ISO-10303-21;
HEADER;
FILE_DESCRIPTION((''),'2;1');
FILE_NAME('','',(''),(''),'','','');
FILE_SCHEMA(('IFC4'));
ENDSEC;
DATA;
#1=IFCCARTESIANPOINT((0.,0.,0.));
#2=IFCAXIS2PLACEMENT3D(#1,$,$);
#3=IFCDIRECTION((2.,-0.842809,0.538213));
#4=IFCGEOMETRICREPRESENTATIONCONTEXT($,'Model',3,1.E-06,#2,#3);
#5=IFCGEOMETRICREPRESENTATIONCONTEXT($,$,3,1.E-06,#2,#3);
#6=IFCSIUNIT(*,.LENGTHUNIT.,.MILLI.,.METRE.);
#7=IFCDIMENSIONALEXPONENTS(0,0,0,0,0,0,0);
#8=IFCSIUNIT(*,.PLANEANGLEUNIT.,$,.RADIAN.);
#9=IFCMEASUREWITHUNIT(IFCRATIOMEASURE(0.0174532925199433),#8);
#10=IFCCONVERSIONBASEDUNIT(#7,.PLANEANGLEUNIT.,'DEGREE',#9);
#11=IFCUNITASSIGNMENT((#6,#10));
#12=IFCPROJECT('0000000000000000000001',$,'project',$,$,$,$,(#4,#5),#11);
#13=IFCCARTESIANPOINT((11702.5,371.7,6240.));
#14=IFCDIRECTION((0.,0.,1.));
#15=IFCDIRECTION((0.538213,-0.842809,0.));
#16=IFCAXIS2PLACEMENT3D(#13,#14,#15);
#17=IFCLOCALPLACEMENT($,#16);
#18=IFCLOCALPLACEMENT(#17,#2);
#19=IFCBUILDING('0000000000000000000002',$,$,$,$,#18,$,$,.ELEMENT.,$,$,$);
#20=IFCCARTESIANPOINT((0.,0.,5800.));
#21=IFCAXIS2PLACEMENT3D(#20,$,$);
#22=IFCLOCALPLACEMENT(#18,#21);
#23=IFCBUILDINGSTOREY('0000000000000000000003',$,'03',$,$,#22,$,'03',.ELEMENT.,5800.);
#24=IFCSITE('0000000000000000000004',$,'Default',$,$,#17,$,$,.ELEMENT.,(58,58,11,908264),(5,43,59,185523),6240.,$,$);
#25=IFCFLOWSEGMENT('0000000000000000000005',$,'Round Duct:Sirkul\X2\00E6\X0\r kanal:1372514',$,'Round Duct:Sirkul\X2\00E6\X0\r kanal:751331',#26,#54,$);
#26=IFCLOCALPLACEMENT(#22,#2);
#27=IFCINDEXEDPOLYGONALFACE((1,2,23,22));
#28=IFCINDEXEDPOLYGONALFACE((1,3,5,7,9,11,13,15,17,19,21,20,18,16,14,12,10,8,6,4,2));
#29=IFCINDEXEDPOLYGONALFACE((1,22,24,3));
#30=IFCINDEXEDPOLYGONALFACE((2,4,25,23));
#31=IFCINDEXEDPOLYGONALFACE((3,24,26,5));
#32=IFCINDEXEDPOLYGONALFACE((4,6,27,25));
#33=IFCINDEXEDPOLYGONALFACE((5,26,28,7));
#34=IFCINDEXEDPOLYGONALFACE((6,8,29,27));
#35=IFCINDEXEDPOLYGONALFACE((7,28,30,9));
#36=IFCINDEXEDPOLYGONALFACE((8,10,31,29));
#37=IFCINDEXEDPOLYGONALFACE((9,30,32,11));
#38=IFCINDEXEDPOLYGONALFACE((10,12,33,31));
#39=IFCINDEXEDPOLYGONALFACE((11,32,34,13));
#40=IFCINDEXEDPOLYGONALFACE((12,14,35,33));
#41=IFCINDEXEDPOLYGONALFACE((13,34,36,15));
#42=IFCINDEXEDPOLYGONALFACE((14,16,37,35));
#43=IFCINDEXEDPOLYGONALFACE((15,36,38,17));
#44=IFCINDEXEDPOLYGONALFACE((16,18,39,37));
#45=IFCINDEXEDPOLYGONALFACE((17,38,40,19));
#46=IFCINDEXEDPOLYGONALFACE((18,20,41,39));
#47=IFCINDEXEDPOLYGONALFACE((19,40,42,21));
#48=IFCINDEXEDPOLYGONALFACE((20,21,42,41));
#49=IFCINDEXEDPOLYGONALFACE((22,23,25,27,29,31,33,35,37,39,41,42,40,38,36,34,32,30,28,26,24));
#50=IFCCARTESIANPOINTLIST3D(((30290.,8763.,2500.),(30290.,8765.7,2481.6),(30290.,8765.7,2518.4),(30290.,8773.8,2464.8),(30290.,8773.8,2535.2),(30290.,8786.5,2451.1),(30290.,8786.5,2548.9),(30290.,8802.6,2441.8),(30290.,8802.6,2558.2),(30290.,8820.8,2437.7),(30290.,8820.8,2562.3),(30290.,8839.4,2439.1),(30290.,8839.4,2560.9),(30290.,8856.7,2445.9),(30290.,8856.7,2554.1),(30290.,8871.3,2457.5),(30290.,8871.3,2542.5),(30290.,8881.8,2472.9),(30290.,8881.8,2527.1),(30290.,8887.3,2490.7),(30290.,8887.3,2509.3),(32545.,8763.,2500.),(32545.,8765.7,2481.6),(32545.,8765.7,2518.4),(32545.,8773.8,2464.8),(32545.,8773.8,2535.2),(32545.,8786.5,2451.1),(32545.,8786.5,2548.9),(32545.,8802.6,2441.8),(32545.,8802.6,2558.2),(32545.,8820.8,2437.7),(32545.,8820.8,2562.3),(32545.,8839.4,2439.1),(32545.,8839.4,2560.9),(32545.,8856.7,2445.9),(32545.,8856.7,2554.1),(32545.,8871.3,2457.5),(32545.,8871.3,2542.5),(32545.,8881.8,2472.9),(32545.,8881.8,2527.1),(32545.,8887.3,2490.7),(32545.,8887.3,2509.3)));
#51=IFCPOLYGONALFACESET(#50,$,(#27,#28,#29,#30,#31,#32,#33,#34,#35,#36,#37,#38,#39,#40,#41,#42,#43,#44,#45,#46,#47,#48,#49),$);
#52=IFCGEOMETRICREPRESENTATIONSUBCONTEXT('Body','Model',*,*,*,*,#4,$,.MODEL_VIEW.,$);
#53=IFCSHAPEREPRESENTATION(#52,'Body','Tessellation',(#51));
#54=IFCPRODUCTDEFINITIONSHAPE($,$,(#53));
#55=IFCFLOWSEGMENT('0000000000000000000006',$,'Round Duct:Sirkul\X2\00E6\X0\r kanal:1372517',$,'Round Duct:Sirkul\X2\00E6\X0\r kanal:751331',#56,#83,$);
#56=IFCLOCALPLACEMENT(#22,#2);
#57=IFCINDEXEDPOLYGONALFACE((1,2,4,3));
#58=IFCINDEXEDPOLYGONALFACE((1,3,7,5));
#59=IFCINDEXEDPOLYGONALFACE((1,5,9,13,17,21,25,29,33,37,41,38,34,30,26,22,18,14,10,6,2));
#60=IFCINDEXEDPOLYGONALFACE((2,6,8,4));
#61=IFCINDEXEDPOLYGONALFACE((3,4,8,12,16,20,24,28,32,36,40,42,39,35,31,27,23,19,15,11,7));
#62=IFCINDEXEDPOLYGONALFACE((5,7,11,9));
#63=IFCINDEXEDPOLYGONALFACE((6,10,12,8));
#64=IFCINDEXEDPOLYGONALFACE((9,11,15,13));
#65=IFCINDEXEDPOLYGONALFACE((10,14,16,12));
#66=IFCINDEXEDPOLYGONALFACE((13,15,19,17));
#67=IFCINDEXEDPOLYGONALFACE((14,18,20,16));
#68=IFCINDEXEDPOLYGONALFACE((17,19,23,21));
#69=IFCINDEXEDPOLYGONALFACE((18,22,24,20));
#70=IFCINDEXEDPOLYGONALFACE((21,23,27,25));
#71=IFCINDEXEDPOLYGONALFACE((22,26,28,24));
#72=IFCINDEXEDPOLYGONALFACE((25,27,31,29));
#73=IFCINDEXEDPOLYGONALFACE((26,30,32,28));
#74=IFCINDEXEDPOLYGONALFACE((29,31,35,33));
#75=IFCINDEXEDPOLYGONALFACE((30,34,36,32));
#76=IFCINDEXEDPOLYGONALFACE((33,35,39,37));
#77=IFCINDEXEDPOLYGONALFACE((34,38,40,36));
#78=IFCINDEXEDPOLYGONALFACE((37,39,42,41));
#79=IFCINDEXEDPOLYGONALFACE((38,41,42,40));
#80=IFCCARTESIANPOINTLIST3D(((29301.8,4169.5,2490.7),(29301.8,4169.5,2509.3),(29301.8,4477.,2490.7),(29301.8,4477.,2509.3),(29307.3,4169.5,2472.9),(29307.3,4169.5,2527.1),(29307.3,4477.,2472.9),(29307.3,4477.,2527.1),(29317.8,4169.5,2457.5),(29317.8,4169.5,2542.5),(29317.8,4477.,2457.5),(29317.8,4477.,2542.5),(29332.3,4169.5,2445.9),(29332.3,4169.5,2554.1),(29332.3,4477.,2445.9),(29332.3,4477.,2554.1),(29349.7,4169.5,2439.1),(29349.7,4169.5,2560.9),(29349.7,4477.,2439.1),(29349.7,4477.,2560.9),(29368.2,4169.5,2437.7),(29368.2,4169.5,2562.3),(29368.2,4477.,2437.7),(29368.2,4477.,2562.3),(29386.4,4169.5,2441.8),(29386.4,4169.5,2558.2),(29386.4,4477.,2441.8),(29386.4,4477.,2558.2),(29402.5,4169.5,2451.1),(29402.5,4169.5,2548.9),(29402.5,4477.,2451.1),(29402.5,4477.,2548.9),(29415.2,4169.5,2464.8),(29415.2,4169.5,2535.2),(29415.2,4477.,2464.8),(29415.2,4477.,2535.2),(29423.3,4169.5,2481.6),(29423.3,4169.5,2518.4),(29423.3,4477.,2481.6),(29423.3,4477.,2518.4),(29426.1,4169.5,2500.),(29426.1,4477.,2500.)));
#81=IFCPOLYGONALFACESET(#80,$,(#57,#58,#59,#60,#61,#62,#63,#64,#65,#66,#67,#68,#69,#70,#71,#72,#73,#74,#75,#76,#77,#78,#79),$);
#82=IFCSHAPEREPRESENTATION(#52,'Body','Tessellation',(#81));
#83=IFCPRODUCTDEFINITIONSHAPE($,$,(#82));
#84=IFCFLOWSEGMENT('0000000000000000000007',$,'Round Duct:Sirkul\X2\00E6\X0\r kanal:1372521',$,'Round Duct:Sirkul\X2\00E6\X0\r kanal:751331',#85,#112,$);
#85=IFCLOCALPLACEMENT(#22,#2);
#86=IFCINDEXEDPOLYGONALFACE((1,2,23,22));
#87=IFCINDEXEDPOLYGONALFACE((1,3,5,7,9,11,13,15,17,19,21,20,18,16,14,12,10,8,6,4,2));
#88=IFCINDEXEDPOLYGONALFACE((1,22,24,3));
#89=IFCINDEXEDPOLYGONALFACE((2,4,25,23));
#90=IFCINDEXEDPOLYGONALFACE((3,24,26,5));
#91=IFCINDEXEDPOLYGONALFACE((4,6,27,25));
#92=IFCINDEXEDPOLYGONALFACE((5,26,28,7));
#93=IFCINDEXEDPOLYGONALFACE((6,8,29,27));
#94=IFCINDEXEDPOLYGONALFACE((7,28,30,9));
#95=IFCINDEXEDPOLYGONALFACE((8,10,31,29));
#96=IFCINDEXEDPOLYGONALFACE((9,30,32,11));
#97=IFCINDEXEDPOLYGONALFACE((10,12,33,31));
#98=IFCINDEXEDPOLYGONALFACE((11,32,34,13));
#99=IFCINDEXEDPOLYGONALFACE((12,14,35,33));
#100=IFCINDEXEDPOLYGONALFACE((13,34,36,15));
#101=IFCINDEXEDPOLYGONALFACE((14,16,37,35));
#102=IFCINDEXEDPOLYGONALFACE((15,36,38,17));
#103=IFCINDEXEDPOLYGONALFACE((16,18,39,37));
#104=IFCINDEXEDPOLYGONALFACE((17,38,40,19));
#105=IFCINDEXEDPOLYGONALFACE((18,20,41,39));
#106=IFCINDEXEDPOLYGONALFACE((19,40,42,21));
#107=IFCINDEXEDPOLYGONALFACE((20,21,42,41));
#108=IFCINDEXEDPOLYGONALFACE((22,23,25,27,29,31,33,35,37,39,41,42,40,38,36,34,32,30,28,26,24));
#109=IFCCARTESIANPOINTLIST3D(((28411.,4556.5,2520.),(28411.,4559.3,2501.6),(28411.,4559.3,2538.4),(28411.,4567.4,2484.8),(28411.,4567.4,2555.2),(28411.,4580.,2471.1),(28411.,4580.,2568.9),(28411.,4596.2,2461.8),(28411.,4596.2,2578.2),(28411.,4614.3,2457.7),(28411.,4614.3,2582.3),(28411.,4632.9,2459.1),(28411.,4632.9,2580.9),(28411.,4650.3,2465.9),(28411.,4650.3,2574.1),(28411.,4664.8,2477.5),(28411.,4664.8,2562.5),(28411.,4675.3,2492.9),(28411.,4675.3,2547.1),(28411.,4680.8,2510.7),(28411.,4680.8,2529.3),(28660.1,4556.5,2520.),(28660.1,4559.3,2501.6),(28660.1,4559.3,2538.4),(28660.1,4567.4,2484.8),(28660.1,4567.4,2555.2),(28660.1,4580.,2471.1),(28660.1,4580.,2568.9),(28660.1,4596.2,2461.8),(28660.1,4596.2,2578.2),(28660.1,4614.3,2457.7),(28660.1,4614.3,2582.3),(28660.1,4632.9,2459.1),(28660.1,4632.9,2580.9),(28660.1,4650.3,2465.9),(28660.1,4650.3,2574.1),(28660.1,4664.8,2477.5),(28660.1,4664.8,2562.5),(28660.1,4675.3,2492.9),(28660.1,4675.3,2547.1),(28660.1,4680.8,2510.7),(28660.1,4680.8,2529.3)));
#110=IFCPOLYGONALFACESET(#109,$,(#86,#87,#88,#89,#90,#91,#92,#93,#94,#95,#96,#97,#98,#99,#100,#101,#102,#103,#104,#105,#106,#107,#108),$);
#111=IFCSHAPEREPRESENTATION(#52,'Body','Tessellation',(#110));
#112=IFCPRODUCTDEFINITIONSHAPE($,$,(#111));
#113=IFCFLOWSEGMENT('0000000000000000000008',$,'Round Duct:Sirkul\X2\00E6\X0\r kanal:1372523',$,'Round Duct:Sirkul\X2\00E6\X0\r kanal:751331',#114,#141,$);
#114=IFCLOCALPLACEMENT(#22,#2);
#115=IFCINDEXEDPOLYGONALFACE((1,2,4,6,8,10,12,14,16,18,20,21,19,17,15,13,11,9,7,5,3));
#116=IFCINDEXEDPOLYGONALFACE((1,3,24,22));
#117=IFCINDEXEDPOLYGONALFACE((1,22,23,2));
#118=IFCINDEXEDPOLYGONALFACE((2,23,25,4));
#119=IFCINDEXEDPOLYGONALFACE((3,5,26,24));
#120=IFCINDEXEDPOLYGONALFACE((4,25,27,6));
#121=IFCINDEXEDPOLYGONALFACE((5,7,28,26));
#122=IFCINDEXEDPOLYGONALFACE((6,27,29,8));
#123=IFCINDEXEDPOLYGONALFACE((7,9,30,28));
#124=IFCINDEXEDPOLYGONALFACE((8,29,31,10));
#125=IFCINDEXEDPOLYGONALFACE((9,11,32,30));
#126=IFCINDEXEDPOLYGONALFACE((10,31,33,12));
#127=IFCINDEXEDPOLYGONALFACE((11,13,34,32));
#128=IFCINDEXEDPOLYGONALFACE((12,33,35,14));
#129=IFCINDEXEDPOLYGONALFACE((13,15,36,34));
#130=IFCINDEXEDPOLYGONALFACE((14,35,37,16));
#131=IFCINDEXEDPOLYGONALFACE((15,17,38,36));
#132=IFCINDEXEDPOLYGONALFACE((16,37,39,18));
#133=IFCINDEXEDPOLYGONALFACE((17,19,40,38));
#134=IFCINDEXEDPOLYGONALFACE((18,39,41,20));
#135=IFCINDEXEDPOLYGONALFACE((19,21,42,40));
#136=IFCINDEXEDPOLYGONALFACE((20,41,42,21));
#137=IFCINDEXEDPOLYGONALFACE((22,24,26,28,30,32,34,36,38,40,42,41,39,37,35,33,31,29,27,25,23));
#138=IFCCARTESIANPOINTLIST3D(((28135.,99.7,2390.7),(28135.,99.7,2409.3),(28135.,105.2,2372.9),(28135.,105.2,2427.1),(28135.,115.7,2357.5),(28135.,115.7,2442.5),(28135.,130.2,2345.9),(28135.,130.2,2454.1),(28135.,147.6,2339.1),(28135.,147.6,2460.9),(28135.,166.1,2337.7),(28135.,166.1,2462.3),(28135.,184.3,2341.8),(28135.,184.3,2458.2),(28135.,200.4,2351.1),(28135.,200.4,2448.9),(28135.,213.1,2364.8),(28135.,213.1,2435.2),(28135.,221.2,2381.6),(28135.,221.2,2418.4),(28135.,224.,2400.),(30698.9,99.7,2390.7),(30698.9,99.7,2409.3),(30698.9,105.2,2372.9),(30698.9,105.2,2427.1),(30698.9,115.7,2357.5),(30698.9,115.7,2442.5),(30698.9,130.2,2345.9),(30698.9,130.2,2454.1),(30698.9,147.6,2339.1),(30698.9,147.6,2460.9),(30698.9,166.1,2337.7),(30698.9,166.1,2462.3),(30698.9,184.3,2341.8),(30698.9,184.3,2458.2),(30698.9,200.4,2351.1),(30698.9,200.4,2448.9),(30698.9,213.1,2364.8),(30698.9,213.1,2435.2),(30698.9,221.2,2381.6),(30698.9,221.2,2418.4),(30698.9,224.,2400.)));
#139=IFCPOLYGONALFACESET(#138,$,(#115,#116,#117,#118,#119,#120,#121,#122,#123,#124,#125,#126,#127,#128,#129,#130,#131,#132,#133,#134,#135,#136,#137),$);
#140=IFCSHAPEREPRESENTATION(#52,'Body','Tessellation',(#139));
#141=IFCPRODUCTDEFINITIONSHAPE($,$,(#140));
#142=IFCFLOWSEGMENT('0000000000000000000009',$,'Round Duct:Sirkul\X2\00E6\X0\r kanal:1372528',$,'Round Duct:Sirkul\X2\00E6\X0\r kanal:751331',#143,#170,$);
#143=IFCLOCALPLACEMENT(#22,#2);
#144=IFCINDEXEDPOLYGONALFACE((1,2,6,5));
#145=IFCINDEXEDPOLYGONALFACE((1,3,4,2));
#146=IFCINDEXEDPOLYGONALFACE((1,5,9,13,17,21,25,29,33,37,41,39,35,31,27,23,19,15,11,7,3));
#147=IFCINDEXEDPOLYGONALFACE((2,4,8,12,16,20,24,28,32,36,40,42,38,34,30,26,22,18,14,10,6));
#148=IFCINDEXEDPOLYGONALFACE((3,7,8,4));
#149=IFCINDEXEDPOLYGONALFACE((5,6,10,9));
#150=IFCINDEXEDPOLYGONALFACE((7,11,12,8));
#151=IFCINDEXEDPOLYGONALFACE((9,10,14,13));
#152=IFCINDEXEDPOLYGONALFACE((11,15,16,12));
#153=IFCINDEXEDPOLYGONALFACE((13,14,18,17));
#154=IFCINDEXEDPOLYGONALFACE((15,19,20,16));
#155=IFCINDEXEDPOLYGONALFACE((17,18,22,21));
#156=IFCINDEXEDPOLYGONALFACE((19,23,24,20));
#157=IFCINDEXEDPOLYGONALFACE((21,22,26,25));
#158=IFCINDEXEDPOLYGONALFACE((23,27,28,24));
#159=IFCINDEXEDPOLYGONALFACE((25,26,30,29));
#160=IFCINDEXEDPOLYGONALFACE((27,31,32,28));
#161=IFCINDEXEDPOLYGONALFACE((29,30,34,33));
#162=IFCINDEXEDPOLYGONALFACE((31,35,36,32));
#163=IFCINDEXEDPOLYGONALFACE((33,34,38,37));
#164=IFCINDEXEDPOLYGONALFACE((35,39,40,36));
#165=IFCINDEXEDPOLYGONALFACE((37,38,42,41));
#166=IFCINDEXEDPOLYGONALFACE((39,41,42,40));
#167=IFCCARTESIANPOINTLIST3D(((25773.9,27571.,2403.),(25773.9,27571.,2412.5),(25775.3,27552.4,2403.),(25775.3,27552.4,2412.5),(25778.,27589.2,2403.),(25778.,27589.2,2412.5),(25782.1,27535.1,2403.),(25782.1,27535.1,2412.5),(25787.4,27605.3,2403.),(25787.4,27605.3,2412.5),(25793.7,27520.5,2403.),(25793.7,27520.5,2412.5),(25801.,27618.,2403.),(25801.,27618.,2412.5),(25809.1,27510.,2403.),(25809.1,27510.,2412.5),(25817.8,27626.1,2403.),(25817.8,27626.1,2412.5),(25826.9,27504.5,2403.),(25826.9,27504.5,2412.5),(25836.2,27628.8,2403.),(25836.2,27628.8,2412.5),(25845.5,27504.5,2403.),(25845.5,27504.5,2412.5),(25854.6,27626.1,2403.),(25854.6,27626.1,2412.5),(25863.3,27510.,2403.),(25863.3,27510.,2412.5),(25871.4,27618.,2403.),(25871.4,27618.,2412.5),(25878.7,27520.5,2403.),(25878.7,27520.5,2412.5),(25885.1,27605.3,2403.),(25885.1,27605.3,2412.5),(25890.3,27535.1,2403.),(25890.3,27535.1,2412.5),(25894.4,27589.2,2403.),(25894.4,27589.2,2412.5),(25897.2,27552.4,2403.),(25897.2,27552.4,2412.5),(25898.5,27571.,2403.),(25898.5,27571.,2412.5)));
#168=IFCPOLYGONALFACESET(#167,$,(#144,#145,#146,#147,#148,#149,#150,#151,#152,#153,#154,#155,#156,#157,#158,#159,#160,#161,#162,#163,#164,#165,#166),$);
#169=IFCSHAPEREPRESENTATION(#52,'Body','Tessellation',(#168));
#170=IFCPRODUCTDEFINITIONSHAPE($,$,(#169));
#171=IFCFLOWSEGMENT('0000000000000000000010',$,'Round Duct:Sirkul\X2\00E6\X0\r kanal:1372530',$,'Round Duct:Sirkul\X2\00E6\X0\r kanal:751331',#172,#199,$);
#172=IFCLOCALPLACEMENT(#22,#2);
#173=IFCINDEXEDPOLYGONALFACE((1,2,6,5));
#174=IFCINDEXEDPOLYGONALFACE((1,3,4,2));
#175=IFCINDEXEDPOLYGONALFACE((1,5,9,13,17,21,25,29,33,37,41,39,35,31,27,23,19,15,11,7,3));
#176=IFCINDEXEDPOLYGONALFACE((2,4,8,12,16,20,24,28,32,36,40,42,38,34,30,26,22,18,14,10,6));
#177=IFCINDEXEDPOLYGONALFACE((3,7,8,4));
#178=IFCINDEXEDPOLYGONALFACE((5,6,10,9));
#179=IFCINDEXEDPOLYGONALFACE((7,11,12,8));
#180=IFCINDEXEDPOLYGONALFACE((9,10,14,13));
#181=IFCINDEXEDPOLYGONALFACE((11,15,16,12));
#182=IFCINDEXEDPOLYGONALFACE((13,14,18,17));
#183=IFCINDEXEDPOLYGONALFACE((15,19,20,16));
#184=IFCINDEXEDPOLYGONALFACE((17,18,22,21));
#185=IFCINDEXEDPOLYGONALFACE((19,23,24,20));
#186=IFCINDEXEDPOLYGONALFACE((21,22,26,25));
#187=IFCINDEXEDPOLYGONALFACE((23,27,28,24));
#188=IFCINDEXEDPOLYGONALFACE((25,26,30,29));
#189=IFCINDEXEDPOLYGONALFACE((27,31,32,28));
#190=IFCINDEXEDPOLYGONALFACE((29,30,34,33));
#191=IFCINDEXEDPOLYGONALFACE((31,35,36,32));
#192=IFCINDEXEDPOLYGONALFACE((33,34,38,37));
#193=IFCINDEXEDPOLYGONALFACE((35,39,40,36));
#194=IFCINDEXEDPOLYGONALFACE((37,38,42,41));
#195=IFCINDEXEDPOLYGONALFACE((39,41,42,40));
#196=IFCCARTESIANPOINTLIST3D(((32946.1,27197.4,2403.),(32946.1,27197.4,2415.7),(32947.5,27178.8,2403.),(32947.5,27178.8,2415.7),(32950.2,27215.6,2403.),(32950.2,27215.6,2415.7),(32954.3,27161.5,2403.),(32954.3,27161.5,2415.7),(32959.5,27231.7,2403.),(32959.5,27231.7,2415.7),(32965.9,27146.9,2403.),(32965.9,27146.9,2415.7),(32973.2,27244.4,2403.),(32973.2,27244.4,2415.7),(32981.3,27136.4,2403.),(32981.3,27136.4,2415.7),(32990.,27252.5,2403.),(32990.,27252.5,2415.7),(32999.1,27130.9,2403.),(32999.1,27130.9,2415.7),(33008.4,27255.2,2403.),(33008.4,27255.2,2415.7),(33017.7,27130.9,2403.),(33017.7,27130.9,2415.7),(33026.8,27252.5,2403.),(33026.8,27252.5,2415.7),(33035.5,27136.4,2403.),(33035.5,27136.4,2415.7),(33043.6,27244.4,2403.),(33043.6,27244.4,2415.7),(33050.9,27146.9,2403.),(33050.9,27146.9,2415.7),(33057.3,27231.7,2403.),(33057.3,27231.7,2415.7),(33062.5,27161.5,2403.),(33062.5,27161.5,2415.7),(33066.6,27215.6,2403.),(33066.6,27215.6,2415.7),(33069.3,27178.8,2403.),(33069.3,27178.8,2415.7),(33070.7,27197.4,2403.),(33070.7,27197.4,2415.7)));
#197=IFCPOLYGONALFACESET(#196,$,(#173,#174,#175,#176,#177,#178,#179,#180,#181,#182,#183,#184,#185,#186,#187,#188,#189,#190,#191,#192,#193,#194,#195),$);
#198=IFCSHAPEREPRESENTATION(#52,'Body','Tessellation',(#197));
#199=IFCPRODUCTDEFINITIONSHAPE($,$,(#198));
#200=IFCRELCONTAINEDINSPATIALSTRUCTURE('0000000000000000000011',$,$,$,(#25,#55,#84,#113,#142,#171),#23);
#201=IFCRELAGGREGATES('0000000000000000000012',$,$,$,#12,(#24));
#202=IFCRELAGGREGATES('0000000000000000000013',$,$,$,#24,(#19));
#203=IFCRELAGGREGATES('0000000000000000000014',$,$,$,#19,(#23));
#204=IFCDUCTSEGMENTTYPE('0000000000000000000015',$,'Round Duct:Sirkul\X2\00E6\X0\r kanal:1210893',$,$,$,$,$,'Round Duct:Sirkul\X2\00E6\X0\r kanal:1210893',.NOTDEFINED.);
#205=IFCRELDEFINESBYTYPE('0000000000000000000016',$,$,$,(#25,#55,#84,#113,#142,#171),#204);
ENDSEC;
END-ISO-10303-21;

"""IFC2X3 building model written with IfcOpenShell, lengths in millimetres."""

from ifc_helpers import new_model, entity, si_unit, converted_unit, direction, frame, frame_2d, origin, origin_2d_with_axis, place, context, subcontext, project, spatial, circle, extrude, type_object, element, save


model = new_model("IFC2X3")

# Units and contexts
model_context = context("Model", 3, precision=1e-06, world=origin(), true_north=direction((2.0, -0.842809, 0.538213)))
context_of_model = context(None, 3, precision=1e-06, world=origin(), true_north=direction((2.0, -0.842809, 0.538213)))
body_context = subcontext(model_context, "Body", "Model", "MODEL_VIEW")
ifc_project = project(units=[si_unit("LENGTHUNIT", "METRE", prefix="MILLI"), converted_unit("PLANEANGLEUNIT", "DEGREE", entity("IfcRatioMeasure", 0.0174532925199433), si_unit("PLANEANGLEUNIT", "RADIAN"), dimensions=[0, 0, 0, 0, 0, 0, 0])], contexts=[model_context, context_of_model])

# Site, building, storey
site_placement = place(None, frame((11702.5, 371.7, 6240.0), z_axis=(0.0, 0.0, 1.0), x_axis=(0.538213, -0.842809, 0.0)))
site = spatial("IfcSite", under=ifc_project, at=site_placement, Name="Default", CompositionType="ELEMENT", RefLatitude=(58, 58, 11, 908264), RefLongitude=(5, 43, 59, 185523), RefElevation=6240.0)
building_placement = place(site_placement, origin())
building = spatial("IfcBuilding", under=site, at=building_placement, CompositionType="ELEMENT")
storey_placement = place(building_placement, frame((0.0, 0.0, 5800.0)))
storey = spatial("IfcBuildingStorey", under=building, at=storey_placement, Name="03", LongName="03", CompositionType="ELEMENT", Elevation=5800.0)

# Flow segments
duct_segment_type_1 = type_object("IfcDuctSegmentType", Name="Round Duct:Sirkulær kanal:1210893", ElementType="Round Duct:Sirkulær kanal:1210893", PredefinedType="NOTDEFINED")
flow_segment_1_placement = place(storey_placement, origin())
element("IfcFlowSegment", 1, at=flow_segment_1_placement, inside=storey, type_object=duct_segment_type_1, Name="Round Duct:Sirkulær kanal:1372514", ObjectType="Round Duct:Sirkulær kanal:751331", context=body_context, shape_type="SweptSolid", body=[
    extrude(circle(Radius=62.5, at=origin_2d_with_axis()), frame((30290.0, 8825.5, 2500.0), z_axis=(1.0, 0.0, 0.0), x_axis=(0.0, -1.0, 0.0)), (0.0, 0.0, 1.0), 2255.0),
])
flow_segment_2_placement = place(storey_placement, origin())
element("IfcFlowSegment", 2, at=flow_segment_2_placement, inside=storey, type_object=duct_segment_type_1, Name="Round Duct:Sirkulær kanal:1372517", ObjectType="Round Duct:Sirkulær kanal:751331", context=body_context, shape_type="SweptSolid", body=[
    extrude(circle(Radius=62.5, at=origin_2d_with_axis()), frame((29363.6, 4169.5, 2500.0), z_axis=(0.0, 1.0, 0.0), x_axis=(1.0, 0.0, 0.0)), (0.0, 0.0, 1.0), 307.5),
])
flow_segment_3_placement = place(storey_placement, origin())
element("IfcFlowSegment", 3, at=flow_segment_3_placement, inside=storey, type_object=duct_segment_type_1, Name="Round Duct:Sirkulær kanal:1372521", ObjectType="Round Duct:Sirkulær kanal:751331", context=body_context, shape_type="SweptSolid", body=[
    extrude(circle(Radius=62.5, at=frame_2d((0.0, 0.0), x_axis=(1.0, 0.0))), frame((28411.0, 4619.0, 2520.0), z_axis=(1.0, 0.0, 0.0), x_axis=(0.0, -1.0, 0.0)), (0.0, 0.0, 1.0), 249.1),
])
flow_segment_4_placement = place(storey_placement, origin())
element("IfcFlowSegment", 4, at=flow_segment_4_placement, inside=storey, type_object=duct_segment_type_1, Name="Round Duct:Sirkulær kanal:1372523", ObjectType="Round Duct:Sirkulær kanal:751331", context=body_context, shape_type="SweptSolid", body=[
    extrude(circle(Radius=62.5, at=frame_2d((0.0, 0.0), x_axis=(1.0, 0.0))), frame((28135.0, 161.5, 2400.0), z_axis=(1.0, 0.0, 0.0), x_axis=(0.0, 1.0, 0.0)), (0.0, 0.0, 1.0), 2563.8),
])
flow_segment_5_placement = place(storey_placement, origin())
element("IfcFlowSegment", 5, at=flow_segment_5_placement, inside=storey, type_object=duct_segment_type_1, Name="Round Duct:Sirkulær kanal:1372528", ObjectType="Round Duct:Sirkulær kanal:751331", context=body_context, shape_type="SweptSolid", body=[
    extrude(circle(Radius=62.5, at=frame_2d((0.0, 0.0), x_axis=(1.0, 0.0))), frame((25836.2, 27566.3, 2403.0), z_axis=(0.0, 0.0, 1.0), x_axis=(0.0, 1.0, 0.0)), (0.0, 0.0, 1.0), 9.5),
])
flow_segment_6_placement = place(storey_placement, origin())
element("IfcFlowSegment", 6, at=flow_segment_6_placement, inside=storey, type_object=duct_segment_type_1, Name="Round Duct:Sirkulær kanal:1372530", ObjectType="Round Duct:Sirkulær kanal:751331", context=body_context, shape_type="SweptSolid", body=[
    extrude(circle(Radius=62.5, at=frame_2d((0.0, 0.0), x_axis=(1.0, 0.0))), frame((33008.4, 27192.7, 2403.0), z_axis=(0.0, 0.0, 1.0), x_axis=(0.0, 1.0, 0.0)), (0.0, 0.0, 1.0), 12.8),
])

save(model, "model.ifc")
